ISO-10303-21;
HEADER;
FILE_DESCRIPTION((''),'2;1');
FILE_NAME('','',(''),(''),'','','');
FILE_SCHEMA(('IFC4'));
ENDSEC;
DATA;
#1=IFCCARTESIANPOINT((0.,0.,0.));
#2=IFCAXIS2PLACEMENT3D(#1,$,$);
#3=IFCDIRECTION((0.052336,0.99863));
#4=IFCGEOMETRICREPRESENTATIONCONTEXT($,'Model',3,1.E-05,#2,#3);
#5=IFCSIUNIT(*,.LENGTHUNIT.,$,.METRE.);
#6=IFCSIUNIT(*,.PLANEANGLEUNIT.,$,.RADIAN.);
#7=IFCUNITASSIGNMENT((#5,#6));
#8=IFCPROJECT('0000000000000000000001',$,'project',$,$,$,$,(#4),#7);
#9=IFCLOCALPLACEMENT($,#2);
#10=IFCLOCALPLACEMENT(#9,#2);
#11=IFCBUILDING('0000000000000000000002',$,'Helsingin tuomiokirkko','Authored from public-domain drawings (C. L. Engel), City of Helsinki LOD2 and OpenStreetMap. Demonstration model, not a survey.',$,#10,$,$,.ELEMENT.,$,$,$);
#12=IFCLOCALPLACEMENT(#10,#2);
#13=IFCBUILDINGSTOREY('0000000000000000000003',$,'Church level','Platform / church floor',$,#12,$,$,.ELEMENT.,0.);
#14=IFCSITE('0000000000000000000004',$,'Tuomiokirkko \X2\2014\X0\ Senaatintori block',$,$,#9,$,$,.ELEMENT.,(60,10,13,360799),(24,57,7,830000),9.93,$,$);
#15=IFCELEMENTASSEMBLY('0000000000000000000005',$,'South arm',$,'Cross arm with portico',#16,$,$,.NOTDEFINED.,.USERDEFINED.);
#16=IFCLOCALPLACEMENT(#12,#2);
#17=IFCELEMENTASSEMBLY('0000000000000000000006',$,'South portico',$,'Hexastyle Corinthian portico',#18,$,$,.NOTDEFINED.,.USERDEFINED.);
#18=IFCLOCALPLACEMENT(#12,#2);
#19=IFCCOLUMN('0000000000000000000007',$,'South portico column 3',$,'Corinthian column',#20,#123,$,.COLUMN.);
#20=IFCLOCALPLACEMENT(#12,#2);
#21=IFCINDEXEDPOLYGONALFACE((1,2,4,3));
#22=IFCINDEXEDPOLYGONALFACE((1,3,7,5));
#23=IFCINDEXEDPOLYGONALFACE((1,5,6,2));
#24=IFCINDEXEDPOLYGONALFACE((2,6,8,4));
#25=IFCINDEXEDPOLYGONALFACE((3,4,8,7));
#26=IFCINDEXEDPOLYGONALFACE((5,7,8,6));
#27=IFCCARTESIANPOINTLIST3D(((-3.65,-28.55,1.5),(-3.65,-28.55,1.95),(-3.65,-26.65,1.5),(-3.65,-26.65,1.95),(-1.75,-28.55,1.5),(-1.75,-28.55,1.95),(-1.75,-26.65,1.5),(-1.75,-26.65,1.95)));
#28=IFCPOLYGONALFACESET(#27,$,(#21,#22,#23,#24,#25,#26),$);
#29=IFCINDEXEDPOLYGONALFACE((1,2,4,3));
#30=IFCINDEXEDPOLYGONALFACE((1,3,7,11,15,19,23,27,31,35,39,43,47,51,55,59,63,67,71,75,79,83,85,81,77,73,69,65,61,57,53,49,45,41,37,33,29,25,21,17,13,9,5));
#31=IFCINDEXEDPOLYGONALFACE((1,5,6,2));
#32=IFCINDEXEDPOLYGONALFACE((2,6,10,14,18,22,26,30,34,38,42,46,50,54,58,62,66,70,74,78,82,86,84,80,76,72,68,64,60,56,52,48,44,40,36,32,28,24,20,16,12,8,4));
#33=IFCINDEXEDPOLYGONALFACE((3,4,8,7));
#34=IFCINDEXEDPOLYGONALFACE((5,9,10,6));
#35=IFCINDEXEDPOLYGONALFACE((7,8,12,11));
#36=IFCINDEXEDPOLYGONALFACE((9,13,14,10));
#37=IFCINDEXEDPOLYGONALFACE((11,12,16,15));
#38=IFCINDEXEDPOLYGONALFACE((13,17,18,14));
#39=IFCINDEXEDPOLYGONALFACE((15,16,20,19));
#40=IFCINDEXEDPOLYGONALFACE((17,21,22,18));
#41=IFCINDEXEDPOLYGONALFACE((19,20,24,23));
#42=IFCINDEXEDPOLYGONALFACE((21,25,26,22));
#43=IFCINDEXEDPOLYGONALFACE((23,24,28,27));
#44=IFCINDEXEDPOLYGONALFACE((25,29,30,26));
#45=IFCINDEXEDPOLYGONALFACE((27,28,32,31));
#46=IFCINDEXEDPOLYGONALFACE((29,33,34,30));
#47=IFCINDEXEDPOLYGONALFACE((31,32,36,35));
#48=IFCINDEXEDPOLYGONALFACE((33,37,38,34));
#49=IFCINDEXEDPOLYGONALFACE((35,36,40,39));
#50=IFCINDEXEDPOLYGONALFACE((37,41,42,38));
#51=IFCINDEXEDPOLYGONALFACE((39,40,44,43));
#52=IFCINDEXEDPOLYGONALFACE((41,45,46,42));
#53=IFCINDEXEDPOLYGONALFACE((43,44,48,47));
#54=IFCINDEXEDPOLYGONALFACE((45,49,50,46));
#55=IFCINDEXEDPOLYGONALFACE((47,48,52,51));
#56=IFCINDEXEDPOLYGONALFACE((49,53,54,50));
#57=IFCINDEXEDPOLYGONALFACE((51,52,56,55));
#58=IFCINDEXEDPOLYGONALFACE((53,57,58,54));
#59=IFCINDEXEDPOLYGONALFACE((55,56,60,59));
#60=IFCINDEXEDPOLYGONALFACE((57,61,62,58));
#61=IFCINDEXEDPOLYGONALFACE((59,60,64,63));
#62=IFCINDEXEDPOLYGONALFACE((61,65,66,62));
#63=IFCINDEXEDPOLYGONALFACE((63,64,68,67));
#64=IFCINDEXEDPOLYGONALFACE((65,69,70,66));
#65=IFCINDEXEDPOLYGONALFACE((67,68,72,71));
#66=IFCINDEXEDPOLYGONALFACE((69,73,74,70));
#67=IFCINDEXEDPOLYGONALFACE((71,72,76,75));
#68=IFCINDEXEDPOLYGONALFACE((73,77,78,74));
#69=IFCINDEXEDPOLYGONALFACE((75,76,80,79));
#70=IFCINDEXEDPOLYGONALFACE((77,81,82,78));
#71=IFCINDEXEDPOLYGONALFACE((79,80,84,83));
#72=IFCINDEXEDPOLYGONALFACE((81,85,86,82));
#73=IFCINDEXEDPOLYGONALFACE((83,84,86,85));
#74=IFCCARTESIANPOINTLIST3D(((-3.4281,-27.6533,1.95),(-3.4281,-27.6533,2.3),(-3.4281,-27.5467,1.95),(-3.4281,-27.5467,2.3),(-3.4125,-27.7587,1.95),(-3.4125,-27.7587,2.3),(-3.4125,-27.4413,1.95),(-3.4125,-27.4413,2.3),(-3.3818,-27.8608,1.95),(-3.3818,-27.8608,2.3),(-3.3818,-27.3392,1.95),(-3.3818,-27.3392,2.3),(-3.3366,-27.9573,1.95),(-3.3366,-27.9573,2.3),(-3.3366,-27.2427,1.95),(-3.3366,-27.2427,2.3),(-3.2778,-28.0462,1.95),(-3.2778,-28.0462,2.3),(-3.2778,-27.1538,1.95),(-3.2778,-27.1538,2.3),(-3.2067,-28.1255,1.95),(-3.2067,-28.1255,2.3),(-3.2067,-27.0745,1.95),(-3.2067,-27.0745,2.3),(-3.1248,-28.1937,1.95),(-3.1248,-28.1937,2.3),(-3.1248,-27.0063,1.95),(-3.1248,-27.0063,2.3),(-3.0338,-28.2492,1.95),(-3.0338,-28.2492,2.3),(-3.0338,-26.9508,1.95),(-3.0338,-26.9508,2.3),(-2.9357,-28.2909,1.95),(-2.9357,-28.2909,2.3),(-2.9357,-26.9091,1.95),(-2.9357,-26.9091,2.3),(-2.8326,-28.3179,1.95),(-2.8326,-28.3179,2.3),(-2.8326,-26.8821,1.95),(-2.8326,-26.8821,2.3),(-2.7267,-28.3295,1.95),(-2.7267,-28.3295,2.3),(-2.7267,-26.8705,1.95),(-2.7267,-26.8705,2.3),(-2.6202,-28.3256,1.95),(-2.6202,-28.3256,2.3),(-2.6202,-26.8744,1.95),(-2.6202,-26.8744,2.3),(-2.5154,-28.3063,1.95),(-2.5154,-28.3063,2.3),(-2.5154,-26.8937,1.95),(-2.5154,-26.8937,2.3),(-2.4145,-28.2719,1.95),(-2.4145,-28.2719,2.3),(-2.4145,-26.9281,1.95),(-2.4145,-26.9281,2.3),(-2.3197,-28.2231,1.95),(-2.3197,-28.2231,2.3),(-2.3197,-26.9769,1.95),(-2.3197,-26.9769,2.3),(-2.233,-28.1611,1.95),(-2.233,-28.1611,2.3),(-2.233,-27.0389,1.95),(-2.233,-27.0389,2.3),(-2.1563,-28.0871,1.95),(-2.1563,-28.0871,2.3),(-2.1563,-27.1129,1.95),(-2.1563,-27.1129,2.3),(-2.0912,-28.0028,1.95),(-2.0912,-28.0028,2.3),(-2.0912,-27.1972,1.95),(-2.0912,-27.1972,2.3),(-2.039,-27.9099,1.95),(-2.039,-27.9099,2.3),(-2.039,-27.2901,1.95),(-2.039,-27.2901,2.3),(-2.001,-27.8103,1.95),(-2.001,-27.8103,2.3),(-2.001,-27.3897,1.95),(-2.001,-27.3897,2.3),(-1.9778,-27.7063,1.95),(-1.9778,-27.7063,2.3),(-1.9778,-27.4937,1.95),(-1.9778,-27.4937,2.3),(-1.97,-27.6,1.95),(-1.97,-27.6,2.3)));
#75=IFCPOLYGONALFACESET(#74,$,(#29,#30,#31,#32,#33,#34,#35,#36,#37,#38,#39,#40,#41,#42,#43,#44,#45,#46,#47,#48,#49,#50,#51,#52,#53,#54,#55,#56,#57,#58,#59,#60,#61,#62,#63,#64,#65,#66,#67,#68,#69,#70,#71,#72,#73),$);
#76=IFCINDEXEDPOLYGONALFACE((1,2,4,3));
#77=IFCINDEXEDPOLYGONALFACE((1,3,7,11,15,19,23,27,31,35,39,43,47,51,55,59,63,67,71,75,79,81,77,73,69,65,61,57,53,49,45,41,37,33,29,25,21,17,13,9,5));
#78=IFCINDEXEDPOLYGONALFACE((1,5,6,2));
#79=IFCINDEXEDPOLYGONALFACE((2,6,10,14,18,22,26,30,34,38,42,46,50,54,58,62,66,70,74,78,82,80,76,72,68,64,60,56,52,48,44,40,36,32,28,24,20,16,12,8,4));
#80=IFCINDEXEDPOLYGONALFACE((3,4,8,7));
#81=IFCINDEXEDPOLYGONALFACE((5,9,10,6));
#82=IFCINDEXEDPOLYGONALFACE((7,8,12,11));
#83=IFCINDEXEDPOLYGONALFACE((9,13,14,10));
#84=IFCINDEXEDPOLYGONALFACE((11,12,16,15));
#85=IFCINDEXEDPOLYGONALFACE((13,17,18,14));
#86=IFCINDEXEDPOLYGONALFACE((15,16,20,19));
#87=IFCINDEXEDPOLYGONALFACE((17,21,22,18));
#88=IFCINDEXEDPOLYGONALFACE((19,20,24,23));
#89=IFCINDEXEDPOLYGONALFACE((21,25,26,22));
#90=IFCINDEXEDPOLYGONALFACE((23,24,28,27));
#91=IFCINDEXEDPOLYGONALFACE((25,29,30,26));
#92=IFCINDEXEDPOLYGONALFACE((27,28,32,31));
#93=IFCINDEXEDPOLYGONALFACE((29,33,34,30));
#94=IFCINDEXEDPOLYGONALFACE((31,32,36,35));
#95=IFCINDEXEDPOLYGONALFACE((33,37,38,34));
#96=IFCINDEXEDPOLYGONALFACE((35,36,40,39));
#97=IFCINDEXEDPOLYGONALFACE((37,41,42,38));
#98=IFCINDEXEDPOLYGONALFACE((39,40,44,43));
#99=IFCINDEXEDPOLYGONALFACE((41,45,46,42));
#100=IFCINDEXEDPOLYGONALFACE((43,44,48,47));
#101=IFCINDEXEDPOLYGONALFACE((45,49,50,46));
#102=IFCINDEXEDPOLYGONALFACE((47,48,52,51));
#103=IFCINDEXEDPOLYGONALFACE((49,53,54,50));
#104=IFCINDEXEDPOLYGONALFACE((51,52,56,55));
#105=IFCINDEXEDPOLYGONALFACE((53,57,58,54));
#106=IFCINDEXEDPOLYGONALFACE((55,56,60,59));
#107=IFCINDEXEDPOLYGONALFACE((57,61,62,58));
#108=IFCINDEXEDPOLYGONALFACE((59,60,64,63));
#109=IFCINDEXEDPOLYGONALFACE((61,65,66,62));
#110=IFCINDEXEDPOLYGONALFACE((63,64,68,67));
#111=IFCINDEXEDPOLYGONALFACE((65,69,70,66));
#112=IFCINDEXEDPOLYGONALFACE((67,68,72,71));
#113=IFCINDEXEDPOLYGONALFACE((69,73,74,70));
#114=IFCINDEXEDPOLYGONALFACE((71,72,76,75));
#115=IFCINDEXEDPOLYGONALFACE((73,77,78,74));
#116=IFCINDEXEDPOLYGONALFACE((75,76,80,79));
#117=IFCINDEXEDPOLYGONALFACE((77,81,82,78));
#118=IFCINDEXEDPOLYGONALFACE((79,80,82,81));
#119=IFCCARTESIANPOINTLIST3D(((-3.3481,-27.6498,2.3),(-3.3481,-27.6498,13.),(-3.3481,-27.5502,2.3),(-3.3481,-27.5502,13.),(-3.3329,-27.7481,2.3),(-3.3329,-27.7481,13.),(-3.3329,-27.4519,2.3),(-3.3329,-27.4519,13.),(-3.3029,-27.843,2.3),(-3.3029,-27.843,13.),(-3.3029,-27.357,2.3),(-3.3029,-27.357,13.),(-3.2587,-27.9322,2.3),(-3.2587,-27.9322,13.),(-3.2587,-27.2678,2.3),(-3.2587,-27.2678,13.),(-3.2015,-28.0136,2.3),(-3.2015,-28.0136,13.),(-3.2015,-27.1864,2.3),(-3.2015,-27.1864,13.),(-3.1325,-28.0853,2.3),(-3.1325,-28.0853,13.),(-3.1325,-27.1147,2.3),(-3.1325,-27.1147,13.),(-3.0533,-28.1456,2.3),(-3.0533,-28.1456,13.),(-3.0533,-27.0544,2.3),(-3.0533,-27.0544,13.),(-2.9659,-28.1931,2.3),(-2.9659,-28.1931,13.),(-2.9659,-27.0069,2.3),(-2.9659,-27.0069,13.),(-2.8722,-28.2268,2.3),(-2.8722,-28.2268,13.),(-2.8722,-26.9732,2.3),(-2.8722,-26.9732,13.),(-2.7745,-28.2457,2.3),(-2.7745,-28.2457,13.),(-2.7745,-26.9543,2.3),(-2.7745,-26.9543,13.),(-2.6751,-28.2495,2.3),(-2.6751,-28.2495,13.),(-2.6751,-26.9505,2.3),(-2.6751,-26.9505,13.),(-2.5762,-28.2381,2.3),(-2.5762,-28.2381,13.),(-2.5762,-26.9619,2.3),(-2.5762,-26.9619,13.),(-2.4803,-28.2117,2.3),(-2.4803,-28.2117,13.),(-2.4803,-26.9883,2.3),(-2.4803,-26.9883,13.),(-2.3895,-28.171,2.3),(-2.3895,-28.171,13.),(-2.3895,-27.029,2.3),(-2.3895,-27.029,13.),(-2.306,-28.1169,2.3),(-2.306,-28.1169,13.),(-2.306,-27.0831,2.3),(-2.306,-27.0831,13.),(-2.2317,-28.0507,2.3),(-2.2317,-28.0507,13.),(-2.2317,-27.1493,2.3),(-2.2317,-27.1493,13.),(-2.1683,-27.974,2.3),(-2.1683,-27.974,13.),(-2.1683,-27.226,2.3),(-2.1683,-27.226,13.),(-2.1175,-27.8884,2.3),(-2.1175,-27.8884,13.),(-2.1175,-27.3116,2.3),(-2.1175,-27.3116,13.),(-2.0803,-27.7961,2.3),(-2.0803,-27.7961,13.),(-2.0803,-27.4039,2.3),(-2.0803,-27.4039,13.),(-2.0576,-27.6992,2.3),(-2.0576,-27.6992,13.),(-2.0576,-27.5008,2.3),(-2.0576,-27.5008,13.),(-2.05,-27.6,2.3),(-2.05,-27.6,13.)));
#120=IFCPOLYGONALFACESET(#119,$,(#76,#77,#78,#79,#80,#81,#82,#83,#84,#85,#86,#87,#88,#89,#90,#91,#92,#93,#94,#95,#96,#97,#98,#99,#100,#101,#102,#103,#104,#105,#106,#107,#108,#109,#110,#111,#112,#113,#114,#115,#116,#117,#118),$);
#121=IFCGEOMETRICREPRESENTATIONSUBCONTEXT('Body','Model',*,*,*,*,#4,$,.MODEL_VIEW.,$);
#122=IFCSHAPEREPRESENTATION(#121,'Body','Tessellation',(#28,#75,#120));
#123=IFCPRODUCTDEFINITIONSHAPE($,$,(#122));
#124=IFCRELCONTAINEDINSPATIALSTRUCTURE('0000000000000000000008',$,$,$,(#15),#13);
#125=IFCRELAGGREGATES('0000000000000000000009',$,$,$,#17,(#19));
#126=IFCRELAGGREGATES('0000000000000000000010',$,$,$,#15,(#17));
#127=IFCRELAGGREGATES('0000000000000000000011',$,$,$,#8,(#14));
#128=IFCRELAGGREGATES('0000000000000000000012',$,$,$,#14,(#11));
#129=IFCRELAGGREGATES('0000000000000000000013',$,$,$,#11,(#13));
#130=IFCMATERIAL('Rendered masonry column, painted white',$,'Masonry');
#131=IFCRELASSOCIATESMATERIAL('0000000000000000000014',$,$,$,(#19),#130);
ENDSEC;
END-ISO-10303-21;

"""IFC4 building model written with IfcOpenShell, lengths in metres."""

from ifc_helpers import new_model, si_unit, direction, frame, origin, origin_2d_with_axis, place, context, subcontext, project, spatial, rectangle, circle, extrude, material, element, aggregate, save


model = new_model("IFC4")

# Units and contexts
model_context = context("Model", 3, precision=1e-05, world=origin(), true_north=direction((0.052336, 0.99863)))
body_context = subcontext(model_context, "Body", "Model", "MODEL_VIEW")
ifc_project = project(units=[si_unit("LENGTHUNIT", "METRE"), si_unit("PLANEANGLEUNIT", "RADIAN")], contexts=[model_context])

# Site, building, storey
site_placement = place(None, origin())
site = spatial("IfcSite", under=ifc_project, at=site_placement, Name="Tuomiokirkko — Senaatintori block", CompositionType="ELEMENT", RefLatitude=(60, 10, 13, 360799), RefLongitude=(24, 57, 7, 830000), RefElevation=9.93)
building_placement = place(site_placement, origin())
building = spatial("IfcBuilding", under=site, at=building_placement, Name="Helsingin tuomiokirkko", Description="Authored from public-domain drawings (C. L. Engel), City of Helsinki LOD2 and OpenStreetMap. Demonstration model, not a survey.", CompositionType="ELEMENT")
storey_placement = place(building_placement, origin())
storey = spatial("IfcBuildingStorey", under=building, at=storey_placement, Name="Church level", Description="Platform / church floor", CompositionType="ELEMENT", Elevation=0.0)

# Element assemblies, column
assembly_1_placement = place(building_placement, origin())
assembly_1 = element("IfcElementAssembly", 1, at=assembly_1_placement, inside=storey, Name="South arm", ObjectType="Cross arm with portico", AssemblyPlace="NOTDEFINED", PredefinedType="USERDEFINED")
assembly_2_placement = place(building_placement, origin())
assembly_2 = element("IfcElementAssembly", 2, at=assembly_2_placement, Name="South portico", ObjectType="Hexastyle Corinthian portico", AssemblyPlace="NOTDEFINED", PredefinedType="USERDEFINED")
ifc_material_1 = material(Name="Rendered masonry column, painted white", Category="Masonry")
column_1_placement = place(building_placement, origin())
column_1 = element("IfcColumn", 3, at=column_1_placement, material=ifc_material_1, Name="South portico column 3", ObjectType="Corinthian column", PredefinedType="COLUMN", context=body_context, shape_type="SweptSolid", body=[
    extrude(rectangle(XDim=1.9, YDim=1.9, at=origin_2d_with_axis()), frame((-2.7, -27.6, 1.5)), (0.0, 0.0, 1.0), 0.45),
    extrude(circle(Radius=0.73, at=origin_2d_with_axis()), frame((-2.7, -27.6, 1.95)), (0.0, 0.0, 1.0), 0.35),
    extrude(circle(Radius=0.65, at=origin_2d_with_axis()), frame((-2.7, -27.6, 2.3)), (0.0, 0.0, 1.0), 10.7),
])
aggregate(assembly_2, [column_1])
aggregate(assembly_1, [assembly_2])

save(model, "model.ifc")
